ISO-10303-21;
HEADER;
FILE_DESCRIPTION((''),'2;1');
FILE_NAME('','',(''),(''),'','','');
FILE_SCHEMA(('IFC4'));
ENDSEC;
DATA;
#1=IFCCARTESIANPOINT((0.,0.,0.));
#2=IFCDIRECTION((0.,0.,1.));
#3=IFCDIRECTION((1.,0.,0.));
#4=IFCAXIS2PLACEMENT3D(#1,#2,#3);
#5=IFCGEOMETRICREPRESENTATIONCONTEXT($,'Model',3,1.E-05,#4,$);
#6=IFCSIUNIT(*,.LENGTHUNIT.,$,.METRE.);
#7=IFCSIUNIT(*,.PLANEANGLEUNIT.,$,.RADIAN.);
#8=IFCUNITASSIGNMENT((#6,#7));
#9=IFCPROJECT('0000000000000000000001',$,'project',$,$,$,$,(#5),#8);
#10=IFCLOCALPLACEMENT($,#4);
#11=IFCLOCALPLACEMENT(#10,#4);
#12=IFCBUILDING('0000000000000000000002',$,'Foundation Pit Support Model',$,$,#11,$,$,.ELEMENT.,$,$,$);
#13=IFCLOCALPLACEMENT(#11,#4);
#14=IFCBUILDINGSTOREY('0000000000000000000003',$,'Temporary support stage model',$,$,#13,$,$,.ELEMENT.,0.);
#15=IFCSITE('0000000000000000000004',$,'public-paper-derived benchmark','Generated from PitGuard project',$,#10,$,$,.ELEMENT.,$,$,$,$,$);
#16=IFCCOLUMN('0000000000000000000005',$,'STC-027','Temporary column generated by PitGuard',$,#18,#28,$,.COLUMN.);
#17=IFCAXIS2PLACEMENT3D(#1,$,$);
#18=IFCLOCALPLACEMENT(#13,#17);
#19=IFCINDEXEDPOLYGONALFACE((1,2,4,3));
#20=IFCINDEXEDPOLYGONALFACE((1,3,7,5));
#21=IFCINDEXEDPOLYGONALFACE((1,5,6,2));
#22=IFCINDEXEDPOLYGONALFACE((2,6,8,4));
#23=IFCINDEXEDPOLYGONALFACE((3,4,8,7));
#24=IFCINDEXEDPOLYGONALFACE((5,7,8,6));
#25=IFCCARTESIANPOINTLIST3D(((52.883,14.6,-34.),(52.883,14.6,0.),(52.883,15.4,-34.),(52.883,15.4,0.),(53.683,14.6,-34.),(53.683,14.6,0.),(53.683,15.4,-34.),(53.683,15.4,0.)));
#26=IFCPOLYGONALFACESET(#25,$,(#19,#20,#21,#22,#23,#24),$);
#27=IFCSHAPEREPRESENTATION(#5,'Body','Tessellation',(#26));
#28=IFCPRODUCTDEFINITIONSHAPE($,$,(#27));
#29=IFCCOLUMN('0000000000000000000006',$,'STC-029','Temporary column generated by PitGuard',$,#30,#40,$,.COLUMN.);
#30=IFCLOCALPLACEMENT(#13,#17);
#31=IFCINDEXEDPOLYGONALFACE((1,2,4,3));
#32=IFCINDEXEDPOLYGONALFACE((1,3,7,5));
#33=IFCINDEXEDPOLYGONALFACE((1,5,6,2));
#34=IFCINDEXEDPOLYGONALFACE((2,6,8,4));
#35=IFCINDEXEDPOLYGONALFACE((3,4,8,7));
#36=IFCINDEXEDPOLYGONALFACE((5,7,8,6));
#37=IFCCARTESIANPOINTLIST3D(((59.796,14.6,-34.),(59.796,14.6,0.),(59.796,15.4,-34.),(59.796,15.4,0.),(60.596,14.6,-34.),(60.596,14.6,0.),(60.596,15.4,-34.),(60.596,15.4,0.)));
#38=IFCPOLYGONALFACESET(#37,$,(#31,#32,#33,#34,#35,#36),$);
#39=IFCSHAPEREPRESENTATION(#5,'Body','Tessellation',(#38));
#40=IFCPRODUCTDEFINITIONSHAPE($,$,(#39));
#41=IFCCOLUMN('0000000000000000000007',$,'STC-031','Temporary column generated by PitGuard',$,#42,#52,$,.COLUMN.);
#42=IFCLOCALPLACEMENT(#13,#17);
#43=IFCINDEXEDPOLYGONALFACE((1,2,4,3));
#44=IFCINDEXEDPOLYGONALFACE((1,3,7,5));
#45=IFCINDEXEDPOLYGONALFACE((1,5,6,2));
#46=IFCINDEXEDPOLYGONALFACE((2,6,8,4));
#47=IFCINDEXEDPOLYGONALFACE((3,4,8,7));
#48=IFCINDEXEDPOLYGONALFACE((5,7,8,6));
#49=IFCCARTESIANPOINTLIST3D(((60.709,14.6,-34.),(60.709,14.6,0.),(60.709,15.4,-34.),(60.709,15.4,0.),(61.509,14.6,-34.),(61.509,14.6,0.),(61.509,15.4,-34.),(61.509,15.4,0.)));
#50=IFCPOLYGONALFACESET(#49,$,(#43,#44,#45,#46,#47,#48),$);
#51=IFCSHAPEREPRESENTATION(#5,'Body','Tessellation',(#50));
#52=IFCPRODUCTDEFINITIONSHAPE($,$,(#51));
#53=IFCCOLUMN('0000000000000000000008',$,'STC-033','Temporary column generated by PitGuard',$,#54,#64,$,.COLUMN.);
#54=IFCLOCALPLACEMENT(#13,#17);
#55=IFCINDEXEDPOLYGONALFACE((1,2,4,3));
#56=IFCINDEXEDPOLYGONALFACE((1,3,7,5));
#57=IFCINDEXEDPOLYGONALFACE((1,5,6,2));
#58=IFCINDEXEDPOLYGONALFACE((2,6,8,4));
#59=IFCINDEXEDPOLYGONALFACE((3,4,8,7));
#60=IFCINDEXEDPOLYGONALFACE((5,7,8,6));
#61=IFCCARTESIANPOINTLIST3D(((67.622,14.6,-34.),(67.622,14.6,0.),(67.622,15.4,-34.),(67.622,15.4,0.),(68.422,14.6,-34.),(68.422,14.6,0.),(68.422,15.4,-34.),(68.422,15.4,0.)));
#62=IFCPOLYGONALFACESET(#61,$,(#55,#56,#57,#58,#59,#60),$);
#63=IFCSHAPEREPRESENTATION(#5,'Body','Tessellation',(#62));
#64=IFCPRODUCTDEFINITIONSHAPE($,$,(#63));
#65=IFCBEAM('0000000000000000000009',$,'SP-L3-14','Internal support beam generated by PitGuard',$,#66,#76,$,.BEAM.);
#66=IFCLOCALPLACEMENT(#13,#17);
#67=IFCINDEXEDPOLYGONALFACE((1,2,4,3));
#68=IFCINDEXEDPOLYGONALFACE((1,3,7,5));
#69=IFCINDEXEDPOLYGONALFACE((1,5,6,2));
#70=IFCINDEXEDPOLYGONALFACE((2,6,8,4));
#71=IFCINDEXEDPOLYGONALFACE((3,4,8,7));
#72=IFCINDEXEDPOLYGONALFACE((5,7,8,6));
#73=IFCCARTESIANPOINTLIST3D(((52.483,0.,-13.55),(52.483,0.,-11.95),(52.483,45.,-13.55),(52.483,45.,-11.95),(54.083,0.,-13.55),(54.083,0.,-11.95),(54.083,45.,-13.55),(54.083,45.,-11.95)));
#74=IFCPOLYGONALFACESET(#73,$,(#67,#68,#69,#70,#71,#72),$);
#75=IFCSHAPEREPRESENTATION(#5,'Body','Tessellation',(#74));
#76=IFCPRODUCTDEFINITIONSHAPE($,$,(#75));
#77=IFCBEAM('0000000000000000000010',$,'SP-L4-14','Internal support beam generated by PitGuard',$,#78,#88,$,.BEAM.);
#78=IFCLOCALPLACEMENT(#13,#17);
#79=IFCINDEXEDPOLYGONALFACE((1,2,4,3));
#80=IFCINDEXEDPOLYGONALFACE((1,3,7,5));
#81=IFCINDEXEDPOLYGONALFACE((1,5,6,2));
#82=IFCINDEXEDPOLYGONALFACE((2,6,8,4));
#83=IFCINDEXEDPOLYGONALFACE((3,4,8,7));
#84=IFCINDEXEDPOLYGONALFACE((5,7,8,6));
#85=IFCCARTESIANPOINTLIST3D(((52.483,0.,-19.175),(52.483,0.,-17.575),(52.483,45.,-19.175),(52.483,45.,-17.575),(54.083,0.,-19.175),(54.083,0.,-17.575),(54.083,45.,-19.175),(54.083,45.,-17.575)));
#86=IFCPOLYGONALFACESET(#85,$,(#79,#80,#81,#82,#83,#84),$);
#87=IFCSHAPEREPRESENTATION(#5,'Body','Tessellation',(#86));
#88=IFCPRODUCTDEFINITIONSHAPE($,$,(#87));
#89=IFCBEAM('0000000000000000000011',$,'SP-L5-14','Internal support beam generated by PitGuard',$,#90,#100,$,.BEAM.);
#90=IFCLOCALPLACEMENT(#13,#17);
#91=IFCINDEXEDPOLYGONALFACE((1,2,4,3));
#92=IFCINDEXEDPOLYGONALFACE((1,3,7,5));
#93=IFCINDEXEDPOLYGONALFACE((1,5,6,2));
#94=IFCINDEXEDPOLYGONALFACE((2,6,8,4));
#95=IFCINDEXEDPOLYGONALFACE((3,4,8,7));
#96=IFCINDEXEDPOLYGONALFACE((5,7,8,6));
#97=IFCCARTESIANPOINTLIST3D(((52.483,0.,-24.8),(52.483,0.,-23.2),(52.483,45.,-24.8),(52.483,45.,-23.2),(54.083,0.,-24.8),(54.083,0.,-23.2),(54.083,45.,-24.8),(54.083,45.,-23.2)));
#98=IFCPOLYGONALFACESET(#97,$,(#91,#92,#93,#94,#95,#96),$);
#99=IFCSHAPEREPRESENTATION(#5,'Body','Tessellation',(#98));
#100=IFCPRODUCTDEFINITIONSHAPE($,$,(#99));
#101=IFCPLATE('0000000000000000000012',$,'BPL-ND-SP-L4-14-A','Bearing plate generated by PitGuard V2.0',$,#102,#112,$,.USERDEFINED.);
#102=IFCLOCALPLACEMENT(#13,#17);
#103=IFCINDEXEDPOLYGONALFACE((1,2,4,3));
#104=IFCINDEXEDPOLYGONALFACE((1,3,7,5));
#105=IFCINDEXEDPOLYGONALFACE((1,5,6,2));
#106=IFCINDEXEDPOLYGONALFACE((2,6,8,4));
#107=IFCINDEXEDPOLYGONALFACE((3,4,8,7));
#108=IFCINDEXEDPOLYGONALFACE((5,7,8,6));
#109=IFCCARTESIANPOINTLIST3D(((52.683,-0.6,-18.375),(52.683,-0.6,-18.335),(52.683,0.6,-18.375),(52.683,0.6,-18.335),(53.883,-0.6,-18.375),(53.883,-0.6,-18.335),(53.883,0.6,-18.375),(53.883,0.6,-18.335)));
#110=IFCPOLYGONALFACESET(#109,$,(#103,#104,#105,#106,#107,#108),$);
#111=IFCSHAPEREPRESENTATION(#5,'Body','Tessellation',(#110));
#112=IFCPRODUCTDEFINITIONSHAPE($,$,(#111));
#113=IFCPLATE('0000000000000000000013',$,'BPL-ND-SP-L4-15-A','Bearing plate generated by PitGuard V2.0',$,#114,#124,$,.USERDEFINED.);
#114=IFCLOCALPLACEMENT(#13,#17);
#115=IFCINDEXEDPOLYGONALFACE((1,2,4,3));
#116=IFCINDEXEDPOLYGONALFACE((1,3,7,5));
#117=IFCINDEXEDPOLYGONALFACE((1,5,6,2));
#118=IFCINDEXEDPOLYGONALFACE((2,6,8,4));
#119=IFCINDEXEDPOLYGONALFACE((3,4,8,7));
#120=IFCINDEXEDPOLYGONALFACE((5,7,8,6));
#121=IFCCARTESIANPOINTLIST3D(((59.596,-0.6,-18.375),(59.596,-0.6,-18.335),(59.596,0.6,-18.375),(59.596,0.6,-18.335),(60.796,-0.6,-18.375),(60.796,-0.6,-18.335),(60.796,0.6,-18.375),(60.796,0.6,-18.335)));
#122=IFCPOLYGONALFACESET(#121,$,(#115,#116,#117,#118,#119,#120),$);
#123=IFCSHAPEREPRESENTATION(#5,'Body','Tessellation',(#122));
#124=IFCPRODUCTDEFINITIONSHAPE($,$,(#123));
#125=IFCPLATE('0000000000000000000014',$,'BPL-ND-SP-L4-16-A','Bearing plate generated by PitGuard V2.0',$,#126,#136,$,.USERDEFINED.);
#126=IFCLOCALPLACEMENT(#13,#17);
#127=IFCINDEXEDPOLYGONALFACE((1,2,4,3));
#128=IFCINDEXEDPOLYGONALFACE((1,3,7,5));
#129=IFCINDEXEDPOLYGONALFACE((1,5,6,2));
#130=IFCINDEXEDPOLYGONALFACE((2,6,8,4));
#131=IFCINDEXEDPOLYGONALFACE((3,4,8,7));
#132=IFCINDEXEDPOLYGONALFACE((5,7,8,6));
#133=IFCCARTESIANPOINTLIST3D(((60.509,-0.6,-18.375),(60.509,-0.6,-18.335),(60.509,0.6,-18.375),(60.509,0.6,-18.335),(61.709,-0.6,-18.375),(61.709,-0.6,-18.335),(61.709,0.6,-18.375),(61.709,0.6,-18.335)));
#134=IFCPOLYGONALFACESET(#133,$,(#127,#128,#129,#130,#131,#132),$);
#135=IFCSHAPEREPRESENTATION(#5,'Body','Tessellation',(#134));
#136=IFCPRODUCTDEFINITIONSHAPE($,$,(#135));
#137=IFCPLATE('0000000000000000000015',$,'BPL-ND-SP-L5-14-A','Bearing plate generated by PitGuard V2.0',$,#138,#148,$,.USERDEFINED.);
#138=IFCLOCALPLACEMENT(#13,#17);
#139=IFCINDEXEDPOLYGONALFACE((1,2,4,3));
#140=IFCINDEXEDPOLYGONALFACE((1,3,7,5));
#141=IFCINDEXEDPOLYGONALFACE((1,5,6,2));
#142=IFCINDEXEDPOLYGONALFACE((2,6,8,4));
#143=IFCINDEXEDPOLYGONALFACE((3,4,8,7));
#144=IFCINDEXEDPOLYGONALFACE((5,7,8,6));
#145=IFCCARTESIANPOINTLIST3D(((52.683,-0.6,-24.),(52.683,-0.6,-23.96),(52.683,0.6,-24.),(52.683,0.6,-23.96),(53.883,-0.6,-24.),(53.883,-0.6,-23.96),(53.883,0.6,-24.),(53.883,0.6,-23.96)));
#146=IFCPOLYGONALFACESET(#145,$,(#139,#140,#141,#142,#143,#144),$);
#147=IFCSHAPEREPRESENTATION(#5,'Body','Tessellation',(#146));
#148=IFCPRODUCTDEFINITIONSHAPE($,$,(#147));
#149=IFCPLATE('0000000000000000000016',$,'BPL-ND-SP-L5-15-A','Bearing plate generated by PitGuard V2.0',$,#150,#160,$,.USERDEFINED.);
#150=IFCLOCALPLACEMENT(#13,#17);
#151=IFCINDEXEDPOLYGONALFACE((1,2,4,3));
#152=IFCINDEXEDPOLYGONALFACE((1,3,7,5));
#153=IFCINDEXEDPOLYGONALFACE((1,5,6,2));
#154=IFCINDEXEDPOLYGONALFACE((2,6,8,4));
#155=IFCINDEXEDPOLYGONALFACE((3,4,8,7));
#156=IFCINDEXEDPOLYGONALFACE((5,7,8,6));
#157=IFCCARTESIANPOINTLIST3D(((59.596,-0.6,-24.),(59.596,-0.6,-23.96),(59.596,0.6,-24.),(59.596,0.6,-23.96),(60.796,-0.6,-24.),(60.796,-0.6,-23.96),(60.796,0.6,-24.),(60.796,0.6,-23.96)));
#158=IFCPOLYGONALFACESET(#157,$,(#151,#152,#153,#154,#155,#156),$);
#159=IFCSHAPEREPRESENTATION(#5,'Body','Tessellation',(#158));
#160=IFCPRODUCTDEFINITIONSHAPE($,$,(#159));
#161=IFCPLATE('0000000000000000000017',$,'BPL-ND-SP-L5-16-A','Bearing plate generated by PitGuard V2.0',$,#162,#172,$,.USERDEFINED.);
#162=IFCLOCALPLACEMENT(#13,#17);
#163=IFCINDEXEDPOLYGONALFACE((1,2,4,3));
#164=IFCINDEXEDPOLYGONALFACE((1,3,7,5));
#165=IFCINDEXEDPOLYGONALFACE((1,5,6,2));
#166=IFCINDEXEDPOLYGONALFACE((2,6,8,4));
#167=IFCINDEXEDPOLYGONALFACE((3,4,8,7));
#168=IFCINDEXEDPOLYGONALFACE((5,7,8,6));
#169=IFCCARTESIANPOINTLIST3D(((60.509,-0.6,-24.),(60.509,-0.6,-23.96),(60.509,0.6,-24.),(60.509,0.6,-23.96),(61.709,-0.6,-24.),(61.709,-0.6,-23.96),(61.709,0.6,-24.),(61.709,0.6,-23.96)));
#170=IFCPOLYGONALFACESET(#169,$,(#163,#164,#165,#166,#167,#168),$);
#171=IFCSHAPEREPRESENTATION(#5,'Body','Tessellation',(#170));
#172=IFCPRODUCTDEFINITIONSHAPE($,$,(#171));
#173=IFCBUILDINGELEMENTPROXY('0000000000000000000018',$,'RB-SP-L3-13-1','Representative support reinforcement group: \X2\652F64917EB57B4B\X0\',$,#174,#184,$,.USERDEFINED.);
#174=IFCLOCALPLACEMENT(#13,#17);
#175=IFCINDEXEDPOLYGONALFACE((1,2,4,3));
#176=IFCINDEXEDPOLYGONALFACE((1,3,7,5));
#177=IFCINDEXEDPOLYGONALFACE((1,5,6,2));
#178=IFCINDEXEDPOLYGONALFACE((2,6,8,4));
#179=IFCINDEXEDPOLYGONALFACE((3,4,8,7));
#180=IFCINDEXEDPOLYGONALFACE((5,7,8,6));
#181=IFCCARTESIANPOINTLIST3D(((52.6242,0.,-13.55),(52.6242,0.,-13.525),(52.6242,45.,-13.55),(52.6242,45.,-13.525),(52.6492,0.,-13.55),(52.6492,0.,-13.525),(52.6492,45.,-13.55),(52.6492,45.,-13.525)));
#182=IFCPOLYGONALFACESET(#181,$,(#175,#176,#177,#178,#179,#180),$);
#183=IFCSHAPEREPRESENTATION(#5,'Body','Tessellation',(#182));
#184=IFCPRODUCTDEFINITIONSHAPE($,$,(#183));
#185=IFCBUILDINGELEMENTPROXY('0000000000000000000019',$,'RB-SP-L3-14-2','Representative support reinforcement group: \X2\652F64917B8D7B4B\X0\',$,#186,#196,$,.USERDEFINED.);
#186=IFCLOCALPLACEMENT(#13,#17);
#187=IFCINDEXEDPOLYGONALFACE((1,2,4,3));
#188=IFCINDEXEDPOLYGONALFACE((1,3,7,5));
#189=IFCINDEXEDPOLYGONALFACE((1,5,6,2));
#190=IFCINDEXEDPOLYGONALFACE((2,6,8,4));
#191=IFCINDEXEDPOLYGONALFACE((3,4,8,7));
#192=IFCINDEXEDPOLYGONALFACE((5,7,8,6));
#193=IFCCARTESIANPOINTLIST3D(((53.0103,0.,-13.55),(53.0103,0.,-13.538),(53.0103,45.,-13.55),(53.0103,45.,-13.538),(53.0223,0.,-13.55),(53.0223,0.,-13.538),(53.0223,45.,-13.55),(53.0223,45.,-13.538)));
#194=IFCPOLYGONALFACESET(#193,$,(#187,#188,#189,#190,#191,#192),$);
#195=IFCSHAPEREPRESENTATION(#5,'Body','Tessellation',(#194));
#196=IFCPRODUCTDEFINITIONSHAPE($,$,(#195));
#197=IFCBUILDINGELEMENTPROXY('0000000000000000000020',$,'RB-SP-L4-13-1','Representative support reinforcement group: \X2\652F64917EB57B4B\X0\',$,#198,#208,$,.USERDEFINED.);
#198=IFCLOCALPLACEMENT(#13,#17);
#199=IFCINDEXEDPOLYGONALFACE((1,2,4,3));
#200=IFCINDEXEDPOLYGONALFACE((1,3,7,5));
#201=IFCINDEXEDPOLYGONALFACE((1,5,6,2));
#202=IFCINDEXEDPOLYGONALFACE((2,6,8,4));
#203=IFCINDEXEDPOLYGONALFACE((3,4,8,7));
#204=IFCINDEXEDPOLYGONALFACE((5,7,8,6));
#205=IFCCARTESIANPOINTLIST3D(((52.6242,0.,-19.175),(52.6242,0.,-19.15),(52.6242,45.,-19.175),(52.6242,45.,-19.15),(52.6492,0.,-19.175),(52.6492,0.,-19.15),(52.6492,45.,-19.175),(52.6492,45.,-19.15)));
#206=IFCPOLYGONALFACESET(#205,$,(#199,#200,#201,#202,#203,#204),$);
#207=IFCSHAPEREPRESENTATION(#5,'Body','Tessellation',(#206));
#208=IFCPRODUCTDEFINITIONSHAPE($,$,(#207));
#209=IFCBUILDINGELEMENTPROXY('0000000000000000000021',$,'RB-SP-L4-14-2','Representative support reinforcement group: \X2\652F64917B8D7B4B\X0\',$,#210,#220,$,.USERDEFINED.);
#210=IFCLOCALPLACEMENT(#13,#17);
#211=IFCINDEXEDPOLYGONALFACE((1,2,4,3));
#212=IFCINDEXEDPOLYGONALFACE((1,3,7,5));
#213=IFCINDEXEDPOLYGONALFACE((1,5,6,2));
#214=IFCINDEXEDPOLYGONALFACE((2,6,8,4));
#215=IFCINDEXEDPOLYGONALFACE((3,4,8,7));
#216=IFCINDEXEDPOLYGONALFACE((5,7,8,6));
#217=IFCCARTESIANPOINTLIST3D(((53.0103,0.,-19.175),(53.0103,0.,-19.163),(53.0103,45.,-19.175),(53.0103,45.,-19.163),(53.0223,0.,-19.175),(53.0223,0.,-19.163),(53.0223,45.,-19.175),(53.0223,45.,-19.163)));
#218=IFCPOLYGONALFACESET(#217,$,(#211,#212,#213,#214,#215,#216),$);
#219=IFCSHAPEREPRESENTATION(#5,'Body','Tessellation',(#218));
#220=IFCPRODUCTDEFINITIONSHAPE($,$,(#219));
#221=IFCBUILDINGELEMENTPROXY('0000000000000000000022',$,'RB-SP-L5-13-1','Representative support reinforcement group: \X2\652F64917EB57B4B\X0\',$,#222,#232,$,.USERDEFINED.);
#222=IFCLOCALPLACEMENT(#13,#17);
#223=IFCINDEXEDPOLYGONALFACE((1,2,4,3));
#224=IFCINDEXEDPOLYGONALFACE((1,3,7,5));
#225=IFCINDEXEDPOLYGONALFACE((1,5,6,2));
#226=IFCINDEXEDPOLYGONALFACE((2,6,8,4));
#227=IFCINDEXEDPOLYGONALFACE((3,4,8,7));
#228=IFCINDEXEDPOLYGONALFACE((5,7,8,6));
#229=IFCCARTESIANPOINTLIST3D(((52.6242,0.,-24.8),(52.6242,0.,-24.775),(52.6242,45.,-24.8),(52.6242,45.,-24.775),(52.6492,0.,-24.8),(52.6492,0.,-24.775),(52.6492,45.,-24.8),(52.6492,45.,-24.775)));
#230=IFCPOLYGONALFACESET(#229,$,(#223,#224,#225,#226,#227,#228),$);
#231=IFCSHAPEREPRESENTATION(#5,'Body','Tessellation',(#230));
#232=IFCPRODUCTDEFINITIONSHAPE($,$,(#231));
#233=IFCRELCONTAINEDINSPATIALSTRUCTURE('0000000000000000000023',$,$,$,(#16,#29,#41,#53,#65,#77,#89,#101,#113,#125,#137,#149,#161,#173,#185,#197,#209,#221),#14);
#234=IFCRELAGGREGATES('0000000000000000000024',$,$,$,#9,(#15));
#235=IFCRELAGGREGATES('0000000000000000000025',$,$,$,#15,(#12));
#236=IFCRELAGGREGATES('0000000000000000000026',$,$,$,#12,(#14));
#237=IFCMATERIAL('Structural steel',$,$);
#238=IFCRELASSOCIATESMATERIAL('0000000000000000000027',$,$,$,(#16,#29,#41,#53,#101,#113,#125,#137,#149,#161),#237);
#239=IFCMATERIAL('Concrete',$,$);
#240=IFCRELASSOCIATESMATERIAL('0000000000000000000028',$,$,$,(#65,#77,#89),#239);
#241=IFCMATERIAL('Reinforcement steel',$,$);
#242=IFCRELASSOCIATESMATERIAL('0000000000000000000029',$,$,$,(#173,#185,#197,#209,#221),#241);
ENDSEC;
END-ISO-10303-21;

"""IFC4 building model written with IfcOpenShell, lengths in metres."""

from ifc_helpers import new_model, si_unit, frame, origin_with_axes, origin_2d, place, context, project, spatial, rectangle, extrude, material, element, save


model = new_model("IFC4")

# Units and contexts
model_context = context("Model", 3, precision=1e-05, world=origin_with_axes())
ifc_project = project(units=[si_unit("LENGTHUNIT", "METRE"), si_unit("PLANEANGLEUNIT", "RADIAN")], contexts=[model_context])

# Site, building, storey
site_placement = place(None, origin_with_axes())
site = spatial("IfcSite", under=ifc_project, at=site_placement, Name="public-paper-derived benchmark", Description="Generated from PitGuard project", CompositionType="ELEMENT")
building_placement = place(site_placement, origin_with_axes())
building = spatial("IfcBuilding", under=site, at=building_placement, Name="Foundation Pit Support Model", CompositionType="ELEMENT")
storey_placement = place(building_placement, origin_with_axes())
storey = spatial("IfcBuildingStorey", under=building, at=storey_placement, Name="Temporary support stage model", CompositionType="ELEMENT", Elevation=0.0)

# Columns
ifc_material_1 = material(Name="Structural steel")
for number, where, z_axis, x_axis, name in (
    (1, (53.283, 15.0, -34.0), (0.0, 0.0, 1.0), (1.0, 0.0, 0.0), "STC-027"),
    (2, (60.196, 15.0, -34.0), (0.0, 0.0, 1.0), (1.0, 0.0, 0.0), "STC-029"),
    (3, (61.109, 15.0, -34.0), (0.0, 0.0, 1.0), (1.0, 0.0, 0.0), "STC-031"),
    (4, (68.022, 15.0, -34.0), (0.0, 0.0, 1.0), (1.0, 0.0, 0.0), "STC-033"),
):
    element("IfcColumn", number, at=place(storey_placement, frame(where, z_axis=z_axis, x_axis=x_axis)), inside=storey, material=ifc_material_1, Name=name, Description="Temporary column generated by PitGuard", PredefinedType="COLUMN", context=model_context, shape_type="SweptSolid", body=[
        extrude(rectangle(XDim=0.8, YDim=0.8, at=origin_2d()), origin_with_axes(), (0.0, 0.0, 1.0), 34.0),
    ])

# Beams
ifc_material_2 = material(Name="Concrete")
for number, where, z_axis, x_axis, name in (
    (5, (53.283, 22.5, -13.55), (0.0, 0.0, 1.0), (0.0, 1.0, 0.0), "SP-L3-14"),
    (6, (53.283, 22.5, -19.175), (0.0, 0.0, 1.0), (0.0, 1.0, 0.0), "SP-L4-14"),
    (7, (53.283, 22.5, -24.8), (0.0, 0.0, 1.0), (0.0, 1.0, 0.0), "SP-L5-14"),
):
    element("IfcBeam", number, at=place(storey_placement, frame(where, z_axis=z_axis, x_axis=x_axis)), inside=storey, material=ifc_material_2, Name=name, Description="Internal support beam generated by PitGuard", PredefinedType="BEAM", context=model_context, shape_type="SweptSolid", body=[
        extrude(rectangle(XDim=45.0, YDim=1.6, at=origin_2d()), origin_with_axes(), (0.0, 0.0, 1.0), 1.6),
    ])

# Plates
for number, where, z_axis, x_axis, name in (
    (8, (53.283, 0.0, -18.375), (0.0, 0.0, 1.0), (1.0, 0.0, 0.0), "BPL-ND-SP-L4-14-A"),
    (9, (60.196, 0.0, -18.375), (0.0, 0.0, 1.0), (1.0, 0.0, 0.0), "BPL-ND-SP-L4-15-A"),
    (10, (61.109, 0.0, -18.375), (0.0, 0.0, 1.0), (1.0, 0.0, 0.0), "BPL-ND-SP-L4-16-A"),
    (11, (53.283, 0.0, -24.0), (0.0, 0.0, 1.0), (1.0, 0.0, 0.0), "BPL-ND-SP-L5-14-A"),
    (12, (60.196, 0.0, -24.0), (0.0, 0.0, 1.0), (1.0, 0.0, 0.0), "BPL-ND-SP-L5-15-A"),
    (13, (61.109, 0.0, -24.0), (0.0, 0.0, 1.0), (1.0, 0.0, 0.0), "BPL-ND-SP-L5-16-A"),
):
    element("IfcPlate", number, at=place(storey_placement, frame(where, z_axis=z_axis, x_axis=x_axis)), inside=storey, material=ifc_material_1, Name=name, Description="Bearing plate generated by PitGuard V2.0", PredefinedType="USERDEFINED", context=model_context, shape_type="SweptSolid", body=[
        extrude(rectangle(XDim=1.2, YDim=1.2, at=origin_2d()), origin_with_axes(), (0.0, 0.0, 1.0), 0.04),
    ])

# Building element proxies
ifc_material_3 = material(Name="Reinforcement steel")
proxy_1_placement = place(storey_placement, frame((52.6367, 22.5, -13.55), z_axis=(0.0, 0.0, 1.0), x_axis=(0.0, 1.0, 0.0)))
element("IfcBuildingElementProxy", 14, at=proxy_1_placement, inside=storey, material=ifc_material_3, Name="RB-SP-L3-13-1", Description="Representative support reinforcement group: 支撑纵筋", PredefinedType="USERDEFINED", context=model_context, shape_type="SweptSolid", body=[
    extrude(rectangle(XDim=45.0, YDim=0.025, at=origin_2d()), origin_with_axes(), (0.0, 0.0, 1.0), 0.025),
])
proxy_2_placement = place(storey_placement, frame((53.0163, 22.5, -13.55), z_axis=(0.0, 0.0, 1.0), x_axis=(0.0, 1.0, 0.0)))
element("IfcBuildingElementProxy", 15, at=proxy_2_placement, inside=storey, material=ifc_material_3, Name="RB-SP-L3-14-2", Description="Representative support reinforcement group: 支撑箍筋", PredefinedType="USERDEFINED", context=model_context, shape_type="SweptSolid", body=[
    extrude(rectangle(XDim=45.0, YDim=0.012, at=origin_2d()), origin_with_axes(), (0.0, 0.0, 1.0), 0.012),
])
proxy_3_placement = place(storey_placement, frame((52.6367, 22.5, -19.175), z_axis=(0.0, 0.0, 1.0), x_axis=(0.0, 1.0, 0.0)))
element("IfcBuildingElementProxy", 16, at=proxy_3_placement, inside=storey, material=ifc_material_3, Name="RB-SP-L4-13-1", Description="Representative support reinforcement group: 支撑纵筋", PredefinedType="USERDEFINED", context=model_context, shape_type="SweptSolid", body=[
    extrude(rectangle(XDim=45.0, YDim=0.025, at=origin_2d()), origin_with_axes(), (0.0, 0.0, 1.0), 0.025),
])
proxy_4_placement = place(storey_placement, frame((53.0163, 22.5, -19.175), z_axis=(0.0, 0.0, 1.0), x_axis=(0.0, 1.0, 0.0)))
element("IfcBuildingElementProxy", 17, at=proxy_4_placement, inside=storey, material=ifc_material_3, Name="RB-SP-L4-14-2", Description="Representative support reinforcement group: 支撑箍筋", PredefinedType="USERDEFINED", context=model_context, shape_type="SweptSolid", body=[
    extrude(rectangle(XDim=45.0, YDim=0.012, at=origin_2d()), origin_with_axes(), (0.0, 0.0, 1.0), 0.012),
])
proxy_5_placement = place(storey_placement, frame((52.6367, 22.5, -24.8), z_axis=(0.0, 0.0, 1.0), x_axis=(0.0, 1.0, 0.0)))
element("IfcBuildingElementProxy", 18, at=proxy_5_placement, inside=storey, material=ifc_material_3, Name="RB-SP-L5-13-1", Description="Representative support reinforcement group: 支撑纵筋", PredefinedType="USERDEFINED", context=model_context, shape_type="SweptSolid", body=[
    extrude(rectangle(XDim=45.0, YDim=0.025, at=origin_2d()), origin_with_axes(), (0.0, 0.0, 1.0), 0.025),
])

save(model, "model.ifc")
